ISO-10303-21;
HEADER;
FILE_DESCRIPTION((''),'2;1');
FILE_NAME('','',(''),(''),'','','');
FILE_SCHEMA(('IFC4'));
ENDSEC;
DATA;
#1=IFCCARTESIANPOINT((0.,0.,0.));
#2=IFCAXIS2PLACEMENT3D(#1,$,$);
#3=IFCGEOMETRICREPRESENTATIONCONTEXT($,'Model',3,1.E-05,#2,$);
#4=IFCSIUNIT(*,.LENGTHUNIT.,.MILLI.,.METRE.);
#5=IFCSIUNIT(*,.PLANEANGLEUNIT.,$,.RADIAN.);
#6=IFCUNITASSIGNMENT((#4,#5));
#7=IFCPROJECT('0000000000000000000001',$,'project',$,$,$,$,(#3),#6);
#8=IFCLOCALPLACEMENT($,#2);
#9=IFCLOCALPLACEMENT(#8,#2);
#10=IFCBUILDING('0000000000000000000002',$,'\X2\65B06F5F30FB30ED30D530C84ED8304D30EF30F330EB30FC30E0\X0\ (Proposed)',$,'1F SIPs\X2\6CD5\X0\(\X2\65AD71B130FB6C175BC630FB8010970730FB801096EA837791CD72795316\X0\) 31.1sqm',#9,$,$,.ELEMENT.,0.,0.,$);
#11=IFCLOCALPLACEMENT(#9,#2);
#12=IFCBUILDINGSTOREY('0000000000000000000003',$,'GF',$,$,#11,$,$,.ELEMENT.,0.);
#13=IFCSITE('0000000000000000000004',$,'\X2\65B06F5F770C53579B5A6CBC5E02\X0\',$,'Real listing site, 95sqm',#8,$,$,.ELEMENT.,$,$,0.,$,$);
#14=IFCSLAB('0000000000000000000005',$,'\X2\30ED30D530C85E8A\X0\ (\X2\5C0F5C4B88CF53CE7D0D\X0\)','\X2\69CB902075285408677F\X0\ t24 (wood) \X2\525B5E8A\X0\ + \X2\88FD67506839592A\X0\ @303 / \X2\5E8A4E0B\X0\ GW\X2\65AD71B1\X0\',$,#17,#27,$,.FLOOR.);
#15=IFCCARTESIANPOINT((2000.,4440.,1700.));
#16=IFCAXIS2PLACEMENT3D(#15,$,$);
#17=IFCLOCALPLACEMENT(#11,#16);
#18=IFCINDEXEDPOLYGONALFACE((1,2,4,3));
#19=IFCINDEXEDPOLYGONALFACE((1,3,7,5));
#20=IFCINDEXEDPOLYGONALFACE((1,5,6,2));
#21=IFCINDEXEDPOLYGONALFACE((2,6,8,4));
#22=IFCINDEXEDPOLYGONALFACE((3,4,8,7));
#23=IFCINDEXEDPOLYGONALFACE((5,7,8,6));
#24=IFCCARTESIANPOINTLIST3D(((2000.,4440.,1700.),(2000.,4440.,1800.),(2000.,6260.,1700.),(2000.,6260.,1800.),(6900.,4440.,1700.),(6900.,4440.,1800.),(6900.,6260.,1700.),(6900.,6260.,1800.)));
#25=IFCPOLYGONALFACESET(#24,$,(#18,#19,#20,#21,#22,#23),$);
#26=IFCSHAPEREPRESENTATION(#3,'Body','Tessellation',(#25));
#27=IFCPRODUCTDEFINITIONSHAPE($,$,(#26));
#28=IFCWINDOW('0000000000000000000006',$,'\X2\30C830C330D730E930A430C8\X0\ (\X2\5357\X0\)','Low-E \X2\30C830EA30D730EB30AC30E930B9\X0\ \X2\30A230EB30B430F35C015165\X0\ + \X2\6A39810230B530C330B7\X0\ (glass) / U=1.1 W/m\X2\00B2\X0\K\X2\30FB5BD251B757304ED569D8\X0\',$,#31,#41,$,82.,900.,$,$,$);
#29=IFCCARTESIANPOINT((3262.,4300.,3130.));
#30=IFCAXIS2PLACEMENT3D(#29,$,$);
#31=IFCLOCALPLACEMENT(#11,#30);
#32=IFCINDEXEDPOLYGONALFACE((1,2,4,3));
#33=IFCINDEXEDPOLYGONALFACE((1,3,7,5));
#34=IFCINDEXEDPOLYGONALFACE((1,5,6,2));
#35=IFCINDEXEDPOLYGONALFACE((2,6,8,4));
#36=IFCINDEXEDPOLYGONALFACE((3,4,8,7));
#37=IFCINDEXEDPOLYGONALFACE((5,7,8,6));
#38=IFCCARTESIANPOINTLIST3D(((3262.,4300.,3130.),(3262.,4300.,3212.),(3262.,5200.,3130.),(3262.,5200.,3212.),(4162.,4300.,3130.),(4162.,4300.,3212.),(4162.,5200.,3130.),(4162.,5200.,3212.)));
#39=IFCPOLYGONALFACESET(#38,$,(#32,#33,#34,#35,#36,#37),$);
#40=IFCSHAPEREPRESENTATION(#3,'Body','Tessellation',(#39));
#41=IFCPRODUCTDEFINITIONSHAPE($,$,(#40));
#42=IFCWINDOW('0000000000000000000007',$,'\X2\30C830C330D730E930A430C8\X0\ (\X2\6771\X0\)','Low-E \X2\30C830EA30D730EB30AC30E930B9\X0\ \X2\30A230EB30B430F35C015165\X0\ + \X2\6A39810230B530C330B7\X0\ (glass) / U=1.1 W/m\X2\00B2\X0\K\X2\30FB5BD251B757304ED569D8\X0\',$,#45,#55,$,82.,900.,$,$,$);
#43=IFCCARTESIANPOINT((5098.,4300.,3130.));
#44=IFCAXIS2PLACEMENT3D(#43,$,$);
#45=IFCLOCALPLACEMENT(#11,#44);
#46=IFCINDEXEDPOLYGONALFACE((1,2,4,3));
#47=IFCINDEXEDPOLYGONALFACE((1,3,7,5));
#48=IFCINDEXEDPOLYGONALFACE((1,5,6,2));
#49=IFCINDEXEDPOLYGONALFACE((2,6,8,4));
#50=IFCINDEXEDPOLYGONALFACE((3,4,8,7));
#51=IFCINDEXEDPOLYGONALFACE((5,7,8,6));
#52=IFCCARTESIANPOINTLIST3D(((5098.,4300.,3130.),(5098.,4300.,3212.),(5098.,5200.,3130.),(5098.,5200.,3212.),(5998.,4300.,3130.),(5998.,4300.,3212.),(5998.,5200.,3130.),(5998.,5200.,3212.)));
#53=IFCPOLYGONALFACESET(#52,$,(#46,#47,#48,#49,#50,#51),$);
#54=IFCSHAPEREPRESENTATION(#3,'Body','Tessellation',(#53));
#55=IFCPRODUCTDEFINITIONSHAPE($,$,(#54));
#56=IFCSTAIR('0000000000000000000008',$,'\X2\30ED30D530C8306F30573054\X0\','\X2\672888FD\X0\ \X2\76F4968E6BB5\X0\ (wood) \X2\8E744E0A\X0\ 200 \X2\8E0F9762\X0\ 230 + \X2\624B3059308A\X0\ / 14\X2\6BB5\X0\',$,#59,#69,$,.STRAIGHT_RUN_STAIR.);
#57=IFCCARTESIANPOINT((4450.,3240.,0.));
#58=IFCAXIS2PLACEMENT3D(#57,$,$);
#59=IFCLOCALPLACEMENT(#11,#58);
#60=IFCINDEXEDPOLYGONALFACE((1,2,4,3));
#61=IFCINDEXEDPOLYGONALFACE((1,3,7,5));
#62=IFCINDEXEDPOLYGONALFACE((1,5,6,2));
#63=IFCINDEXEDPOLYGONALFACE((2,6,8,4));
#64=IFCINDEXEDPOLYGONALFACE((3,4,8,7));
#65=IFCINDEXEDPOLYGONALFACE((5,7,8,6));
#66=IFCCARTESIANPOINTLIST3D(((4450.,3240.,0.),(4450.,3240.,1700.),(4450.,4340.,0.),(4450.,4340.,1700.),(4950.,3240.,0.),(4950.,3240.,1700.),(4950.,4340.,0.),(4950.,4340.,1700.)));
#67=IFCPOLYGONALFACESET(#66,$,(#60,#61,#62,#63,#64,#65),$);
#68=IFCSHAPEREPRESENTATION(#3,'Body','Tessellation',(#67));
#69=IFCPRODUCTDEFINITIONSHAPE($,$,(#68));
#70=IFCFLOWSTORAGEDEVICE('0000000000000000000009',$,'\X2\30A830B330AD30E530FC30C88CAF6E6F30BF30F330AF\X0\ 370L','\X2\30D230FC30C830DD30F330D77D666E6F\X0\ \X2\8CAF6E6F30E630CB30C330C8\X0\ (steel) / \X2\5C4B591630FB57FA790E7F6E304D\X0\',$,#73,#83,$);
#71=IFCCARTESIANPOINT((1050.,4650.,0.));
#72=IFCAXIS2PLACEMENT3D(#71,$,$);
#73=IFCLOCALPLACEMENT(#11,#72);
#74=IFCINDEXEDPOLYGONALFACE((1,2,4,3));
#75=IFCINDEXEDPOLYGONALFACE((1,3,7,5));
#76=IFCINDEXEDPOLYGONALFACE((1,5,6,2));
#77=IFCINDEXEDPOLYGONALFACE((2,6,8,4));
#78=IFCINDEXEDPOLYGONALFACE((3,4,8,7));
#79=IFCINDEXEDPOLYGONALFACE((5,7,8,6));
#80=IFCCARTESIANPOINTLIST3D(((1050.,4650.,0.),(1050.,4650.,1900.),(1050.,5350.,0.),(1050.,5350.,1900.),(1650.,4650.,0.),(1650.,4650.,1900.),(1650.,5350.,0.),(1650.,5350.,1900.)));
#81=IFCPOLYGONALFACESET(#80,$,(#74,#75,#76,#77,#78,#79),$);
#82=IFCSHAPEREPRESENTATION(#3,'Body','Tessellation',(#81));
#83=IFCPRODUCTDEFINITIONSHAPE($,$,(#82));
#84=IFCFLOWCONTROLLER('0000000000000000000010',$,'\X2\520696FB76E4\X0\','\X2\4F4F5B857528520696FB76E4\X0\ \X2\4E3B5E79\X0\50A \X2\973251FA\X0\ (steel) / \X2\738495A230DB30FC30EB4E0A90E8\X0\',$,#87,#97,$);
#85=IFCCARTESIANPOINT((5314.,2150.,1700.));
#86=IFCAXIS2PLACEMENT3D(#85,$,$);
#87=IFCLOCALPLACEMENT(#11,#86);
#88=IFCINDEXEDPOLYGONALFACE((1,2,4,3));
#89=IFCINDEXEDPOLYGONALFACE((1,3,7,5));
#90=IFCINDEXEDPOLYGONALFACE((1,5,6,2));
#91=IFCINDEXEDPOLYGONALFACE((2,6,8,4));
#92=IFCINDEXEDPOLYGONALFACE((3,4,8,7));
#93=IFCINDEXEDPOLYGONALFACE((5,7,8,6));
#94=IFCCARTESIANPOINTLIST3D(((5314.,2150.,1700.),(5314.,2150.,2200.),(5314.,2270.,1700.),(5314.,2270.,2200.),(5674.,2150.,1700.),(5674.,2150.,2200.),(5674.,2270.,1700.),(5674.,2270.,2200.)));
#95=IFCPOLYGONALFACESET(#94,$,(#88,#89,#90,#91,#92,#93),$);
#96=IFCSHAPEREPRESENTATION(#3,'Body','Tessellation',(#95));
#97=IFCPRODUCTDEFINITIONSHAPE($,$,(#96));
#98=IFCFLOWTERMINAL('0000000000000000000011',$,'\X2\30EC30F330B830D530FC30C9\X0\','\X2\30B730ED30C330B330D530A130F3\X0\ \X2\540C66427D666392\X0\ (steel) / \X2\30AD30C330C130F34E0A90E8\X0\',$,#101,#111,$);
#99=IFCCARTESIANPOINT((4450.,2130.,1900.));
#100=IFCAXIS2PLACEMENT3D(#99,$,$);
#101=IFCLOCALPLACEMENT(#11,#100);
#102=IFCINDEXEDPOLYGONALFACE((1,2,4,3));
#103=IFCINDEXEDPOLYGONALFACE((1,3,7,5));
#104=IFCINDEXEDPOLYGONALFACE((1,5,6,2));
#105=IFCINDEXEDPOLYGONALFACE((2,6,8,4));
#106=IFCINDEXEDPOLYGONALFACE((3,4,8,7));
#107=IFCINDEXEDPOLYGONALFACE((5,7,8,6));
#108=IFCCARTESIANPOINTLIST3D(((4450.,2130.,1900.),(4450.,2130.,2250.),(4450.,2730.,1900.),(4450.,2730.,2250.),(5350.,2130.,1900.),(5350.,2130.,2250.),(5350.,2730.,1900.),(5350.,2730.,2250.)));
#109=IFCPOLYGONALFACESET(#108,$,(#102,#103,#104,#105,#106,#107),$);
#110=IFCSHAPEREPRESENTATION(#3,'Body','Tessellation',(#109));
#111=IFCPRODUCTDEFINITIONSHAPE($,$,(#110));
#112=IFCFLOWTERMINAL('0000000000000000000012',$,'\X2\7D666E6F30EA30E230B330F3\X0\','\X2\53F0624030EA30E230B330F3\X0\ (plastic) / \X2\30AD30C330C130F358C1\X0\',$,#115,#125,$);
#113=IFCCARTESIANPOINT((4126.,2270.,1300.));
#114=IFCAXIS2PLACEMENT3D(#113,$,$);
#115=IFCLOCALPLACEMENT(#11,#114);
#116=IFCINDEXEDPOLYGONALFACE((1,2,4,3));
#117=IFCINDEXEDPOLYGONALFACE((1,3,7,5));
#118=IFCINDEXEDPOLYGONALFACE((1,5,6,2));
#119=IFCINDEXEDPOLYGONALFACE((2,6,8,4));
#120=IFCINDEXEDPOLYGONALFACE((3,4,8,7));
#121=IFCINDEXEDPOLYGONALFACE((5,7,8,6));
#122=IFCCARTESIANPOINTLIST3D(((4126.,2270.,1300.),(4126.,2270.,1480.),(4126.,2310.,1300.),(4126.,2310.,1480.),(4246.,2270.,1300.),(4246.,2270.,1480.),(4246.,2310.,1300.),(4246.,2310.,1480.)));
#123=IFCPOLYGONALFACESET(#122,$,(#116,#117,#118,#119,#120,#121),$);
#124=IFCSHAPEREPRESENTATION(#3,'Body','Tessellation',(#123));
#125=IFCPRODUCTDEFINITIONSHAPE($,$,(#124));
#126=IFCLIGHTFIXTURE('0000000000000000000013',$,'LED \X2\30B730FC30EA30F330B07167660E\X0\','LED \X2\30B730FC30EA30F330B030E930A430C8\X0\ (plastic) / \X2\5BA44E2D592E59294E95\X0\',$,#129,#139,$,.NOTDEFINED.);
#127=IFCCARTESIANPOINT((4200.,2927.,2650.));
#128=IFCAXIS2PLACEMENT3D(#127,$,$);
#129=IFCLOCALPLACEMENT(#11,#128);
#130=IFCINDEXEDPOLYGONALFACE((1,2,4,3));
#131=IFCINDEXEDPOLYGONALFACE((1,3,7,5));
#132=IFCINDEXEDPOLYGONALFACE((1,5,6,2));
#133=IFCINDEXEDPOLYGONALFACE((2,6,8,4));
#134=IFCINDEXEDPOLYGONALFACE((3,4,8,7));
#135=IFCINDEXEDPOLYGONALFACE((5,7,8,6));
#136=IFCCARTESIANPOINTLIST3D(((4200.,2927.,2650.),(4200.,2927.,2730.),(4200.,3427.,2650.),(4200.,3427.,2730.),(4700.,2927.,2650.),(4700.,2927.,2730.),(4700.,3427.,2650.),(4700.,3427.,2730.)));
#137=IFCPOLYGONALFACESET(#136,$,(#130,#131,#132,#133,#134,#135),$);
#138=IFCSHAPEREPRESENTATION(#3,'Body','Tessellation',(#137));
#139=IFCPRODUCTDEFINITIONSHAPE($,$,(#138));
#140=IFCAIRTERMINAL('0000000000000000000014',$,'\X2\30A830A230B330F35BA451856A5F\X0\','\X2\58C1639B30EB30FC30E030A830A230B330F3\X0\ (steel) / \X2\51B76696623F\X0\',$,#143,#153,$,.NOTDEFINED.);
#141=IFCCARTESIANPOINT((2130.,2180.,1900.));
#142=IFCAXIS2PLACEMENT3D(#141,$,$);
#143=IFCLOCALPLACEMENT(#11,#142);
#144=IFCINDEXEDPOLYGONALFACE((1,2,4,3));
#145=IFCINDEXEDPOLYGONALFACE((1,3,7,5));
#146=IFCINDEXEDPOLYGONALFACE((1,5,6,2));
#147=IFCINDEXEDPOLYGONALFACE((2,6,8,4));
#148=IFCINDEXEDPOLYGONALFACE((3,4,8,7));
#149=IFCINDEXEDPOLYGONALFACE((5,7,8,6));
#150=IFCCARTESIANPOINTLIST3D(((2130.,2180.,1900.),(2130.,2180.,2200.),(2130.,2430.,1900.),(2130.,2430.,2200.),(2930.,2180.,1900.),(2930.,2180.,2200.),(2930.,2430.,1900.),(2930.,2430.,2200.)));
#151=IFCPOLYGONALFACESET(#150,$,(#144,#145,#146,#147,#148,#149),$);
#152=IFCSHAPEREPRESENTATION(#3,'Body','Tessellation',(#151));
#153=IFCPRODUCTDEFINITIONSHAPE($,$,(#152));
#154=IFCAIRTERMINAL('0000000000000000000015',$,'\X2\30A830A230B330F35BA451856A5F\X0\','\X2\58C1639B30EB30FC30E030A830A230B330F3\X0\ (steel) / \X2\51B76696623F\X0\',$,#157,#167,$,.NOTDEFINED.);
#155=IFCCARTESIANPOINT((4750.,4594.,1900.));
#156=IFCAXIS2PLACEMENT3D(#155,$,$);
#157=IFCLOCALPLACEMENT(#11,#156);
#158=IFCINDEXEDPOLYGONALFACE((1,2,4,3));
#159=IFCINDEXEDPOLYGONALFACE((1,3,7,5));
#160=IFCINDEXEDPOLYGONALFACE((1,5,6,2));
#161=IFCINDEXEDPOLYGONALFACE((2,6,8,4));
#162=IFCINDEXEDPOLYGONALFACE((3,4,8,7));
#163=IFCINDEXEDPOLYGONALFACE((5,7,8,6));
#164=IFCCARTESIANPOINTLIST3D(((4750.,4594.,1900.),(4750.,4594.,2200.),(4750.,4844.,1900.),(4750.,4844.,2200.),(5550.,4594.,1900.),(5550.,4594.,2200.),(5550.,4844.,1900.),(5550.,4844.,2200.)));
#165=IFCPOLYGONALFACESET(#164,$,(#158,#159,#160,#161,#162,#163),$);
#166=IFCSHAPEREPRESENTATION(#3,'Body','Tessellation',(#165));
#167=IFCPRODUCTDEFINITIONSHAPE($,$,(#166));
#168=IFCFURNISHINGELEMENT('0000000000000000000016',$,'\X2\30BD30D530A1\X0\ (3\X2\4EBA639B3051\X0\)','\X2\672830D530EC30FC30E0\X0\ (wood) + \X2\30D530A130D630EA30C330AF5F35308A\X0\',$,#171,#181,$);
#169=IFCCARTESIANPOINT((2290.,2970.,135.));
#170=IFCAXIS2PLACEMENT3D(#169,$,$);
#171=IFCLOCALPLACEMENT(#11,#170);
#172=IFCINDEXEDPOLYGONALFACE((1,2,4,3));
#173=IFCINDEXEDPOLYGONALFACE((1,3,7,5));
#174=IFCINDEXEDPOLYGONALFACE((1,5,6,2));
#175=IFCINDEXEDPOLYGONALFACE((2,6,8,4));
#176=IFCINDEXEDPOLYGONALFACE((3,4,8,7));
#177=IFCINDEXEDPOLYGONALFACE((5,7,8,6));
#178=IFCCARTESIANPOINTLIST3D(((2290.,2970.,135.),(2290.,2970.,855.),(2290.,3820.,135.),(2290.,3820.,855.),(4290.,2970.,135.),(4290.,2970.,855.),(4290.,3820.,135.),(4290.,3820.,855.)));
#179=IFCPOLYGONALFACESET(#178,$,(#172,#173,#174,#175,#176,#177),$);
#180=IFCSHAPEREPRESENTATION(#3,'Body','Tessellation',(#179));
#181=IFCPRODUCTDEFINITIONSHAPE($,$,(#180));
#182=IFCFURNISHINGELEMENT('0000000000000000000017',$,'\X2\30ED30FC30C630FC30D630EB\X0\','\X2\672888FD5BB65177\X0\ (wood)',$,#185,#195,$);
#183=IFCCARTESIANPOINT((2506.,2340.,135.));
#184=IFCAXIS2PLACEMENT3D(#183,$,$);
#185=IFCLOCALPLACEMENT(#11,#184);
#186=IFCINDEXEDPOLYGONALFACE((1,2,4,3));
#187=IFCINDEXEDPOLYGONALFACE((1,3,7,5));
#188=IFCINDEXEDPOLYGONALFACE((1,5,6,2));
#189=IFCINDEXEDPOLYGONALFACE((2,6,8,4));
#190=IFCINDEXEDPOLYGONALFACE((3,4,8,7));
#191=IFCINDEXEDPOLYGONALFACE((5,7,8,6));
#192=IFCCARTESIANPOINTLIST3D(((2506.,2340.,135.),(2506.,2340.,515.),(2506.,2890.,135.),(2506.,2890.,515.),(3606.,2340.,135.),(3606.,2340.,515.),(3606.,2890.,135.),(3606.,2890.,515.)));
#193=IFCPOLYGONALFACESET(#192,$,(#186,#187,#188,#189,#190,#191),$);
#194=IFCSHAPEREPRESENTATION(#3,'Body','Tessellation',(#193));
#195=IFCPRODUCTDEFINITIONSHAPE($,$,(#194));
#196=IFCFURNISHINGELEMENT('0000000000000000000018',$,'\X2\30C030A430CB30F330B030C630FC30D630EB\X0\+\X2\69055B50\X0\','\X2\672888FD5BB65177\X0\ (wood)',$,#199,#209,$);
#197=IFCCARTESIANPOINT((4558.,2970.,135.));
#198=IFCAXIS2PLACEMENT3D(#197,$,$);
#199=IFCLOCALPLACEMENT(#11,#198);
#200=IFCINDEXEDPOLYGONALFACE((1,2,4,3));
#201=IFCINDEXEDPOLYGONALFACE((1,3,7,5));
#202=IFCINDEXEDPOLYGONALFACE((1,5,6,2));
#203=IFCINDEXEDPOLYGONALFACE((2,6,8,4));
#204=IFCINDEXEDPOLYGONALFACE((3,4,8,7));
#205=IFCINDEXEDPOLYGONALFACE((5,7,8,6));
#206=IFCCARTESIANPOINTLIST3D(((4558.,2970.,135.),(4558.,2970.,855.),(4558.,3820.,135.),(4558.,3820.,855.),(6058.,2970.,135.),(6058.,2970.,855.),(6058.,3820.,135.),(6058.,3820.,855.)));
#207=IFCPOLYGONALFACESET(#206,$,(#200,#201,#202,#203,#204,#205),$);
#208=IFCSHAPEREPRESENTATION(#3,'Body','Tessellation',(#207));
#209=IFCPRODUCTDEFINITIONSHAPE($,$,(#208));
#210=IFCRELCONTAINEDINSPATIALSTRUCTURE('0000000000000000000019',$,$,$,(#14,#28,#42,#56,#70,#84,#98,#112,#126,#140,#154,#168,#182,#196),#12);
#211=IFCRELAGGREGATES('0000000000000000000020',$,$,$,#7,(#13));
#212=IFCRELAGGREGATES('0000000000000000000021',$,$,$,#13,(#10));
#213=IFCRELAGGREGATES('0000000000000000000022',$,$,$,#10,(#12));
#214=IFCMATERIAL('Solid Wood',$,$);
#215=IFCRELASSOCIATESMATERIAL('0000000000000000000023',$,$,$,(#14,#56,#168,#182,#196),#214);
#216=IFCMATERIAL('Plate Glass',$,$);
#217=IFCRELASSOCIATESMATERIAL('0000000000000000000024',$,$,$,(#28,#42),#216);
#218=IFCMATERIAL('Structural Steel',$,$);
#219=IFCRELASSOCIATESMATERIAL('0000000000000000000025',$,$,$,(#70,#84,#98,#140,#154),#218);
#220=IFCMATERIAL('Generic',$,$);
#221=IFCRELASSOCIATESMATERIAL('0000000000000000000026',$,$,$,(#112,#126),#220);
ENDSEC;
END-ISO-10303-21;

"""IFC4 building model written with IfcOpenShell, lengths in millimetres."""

from ifc_helpers import new_model, si_unit, frame, frame_2d, origin, place, context, project, spatial, rectangle, extrude, material, element, save


model = new_model("IFC4")

# Units and contexts
model_context = context("Model", 3, precision=1e-05, world=origin())
ifc_project = project(units=[si_unit("LENGTHUNIT", "METRE", prefix="MILLI"), si_unit("PLANEANGLEUNIT", "RADIAN")], contexts=[model_context])

# Site, building, storey
site_placement = place(None, origin())
site = spatial("IfcSite", under=ifc_project, at=site_placement, Name="新潟県南魚沼市", ObjectType="Real listing site, 95sqm", CompositionType="ELEMENT", RefElevation=0.0)
building_placement = place(site_placement, origin())
building = spatial("IfcBuilding", under=site, at=building_placement, Name="新潟・ロフト付きワンルーム (Proposed)", ObjectType="1F SIPs法(断熱・気密・耐震・耐雪荷重特化) 31.1sqm", CompositionType="ELEMENT", ElevationOfRefHeight=0.0, ElevationOfTerrain=0.0)
storey_placement = place(building_placement, origin())
storey = spatial("IfcBuildingStorey", under=building, at=storey_placement, Name="GF", CompositionType="ELEMENT", Elevation=0.0)

# Shared definitions
ifc_material_1 = material(Name="Solid Wood")

# Slab
slab_placement = place(storey_placement, frame((2000.0, 4440.0, 1700.0)))
element("IfcSlab", 1, at=slab_placement, inside=storey, material=ifc_material_1, Name="ロフト床 (小屋裏収納)", Description="構造用合板 t24 (wood) 剛床 + 製材根太 @303 / 床下 GW断熱", PredefinedType="FLOOR", context=model_context, shape_type="SweptSolid", body=[
    extrude(rectangle(XDim=4900.0, YDim=1820.0, at=frame_2d((2450.0, 910.0))), frame((2000.0, 4440.0, 1700.0)), (0.0, 0.0, 1.0), 100.0),
])

# Windows
ifc_material_2 = material(Name="Plate Glass")
window_1_placement = place(storey_placement, frame((3262.0, 4300.0, 3130.0)))
element("IfcWindow", 2, at=window_1_placement, inside=storey, material=ifc_material_2, Name="トップライト (南)", Description="Low-E トリプルガラス アルゴン封入 + 樹脂サッシ (glass) / U=1.1 W/m²K・寒冷地仕様", OverallHeight=82.0, OverallWidth=900.0, context=model_context, shape_type="SweptSolid", body=[
    extrude(rectangle(XDim=900.0, YDim=900.0, at=frame_2d((450.0, 450.0))), frame((3262.0, 4300.0, 3130.0)), (0.0, 0.0, 1.0), 82.0),
])
window_2_placement = place(storey_placement, frame((5098.0, 4300.0, 3130.0)))
element("IfcWindow", 3, at=window_2_placement, inside=storey, material=ifc_material_2, Name="トップライト (東)", Description="Low-E トリプルガラス アルゴン封入 + 樹脂サッシ (glass) / U=1.1 W/m²K・寒冷地仕様", OverallHeight=82.0, OverallWidth=900.0, context=model_context, shape_type="SweptSolid", body=[
    extrude(rectangle(XDim=900.0, YDim=900.0, at=frame_2d((450.0, 450.0))), frame((5098.0, 4300.0, 3130.0)), (0.0, 0.0, 1.0), 82.0),
])

# Stair
stair_placement = place(storey_placement, frame((4450.0, 3240.0, 0.0)))
element("IfcStair", 4, at=stair_placement, inside=storey, material=ifc_material_1, Name="ロフトはしご", Description="木製 直階段 (wood) 蹴上 200 踏面 230 + 手すり / 14段", PredefinedType="STRAIGHT_RUN_STAIR", context=model_context, shape_type="SweptSolid", body=[
    extrude(rectangle(XDim=500.0, YDim=1100.0, at=frame_2d((250.0, 550.0))), frame((4450.0, 3240.0, 0.0)), (0.0, 0.0, 1.0), 1700.0),
])

# Flow storage device
ifc_material_3 = material(Name="Structural Steel")
flow_storage_device_placement = place(storey_placement, frame((1050.0, 4650.0, 0.0)))
element("IfcFlowStorageDevice", 5, at=flow_storage_device_placement, inside=storey, material=ifc_material_3, Name="エコキュート貯湯タンク 370L", Description="ヒートポンプ給湯 貯湯ユニット (steel) / 屋外・基礎置き", context=model_context, shape_type="SweptSolid", body=[
    extrude(rectangle(XDim=600.0, YDim=700.0, at=frame_2d((300.0, 350.0))), frame((1050.0, 4650.0, 0.0)), (0.0, 0.0, 1.0), 1900.0),
])

# Flow controller
flow_controller_placement = place(storey_placement, frame((5314.0, 2150.0, 1700.0)))
element("IfcFlowController", 6, at=flow_controller_placement, inside=storey, material=ifc_material_3, Name="分電盤", Description="住宅用分電盤 主幹50A 露出 (steel) / 玄関ホール上部", context=model_context, shape_type="SweptSolid", body=[
    extrude(rectangle(XDim=360.0, YDim=120.0, at=frame_2d((180.0, 60.0))), frame((5314.0, 2150.0, 1700.0)), (0.0, 0.0, 1.0), 500.0),
])

# Flow terminals
flow_terminal_1_placement = place(storey_placement, frame((4450.0, 2130.0, 1900.0)))
element("IfcFlowTerminal", 7, at=flow_terminal_1_placement, inside=storey, material=ifc_material_3, Name="レンジフード", Description="シロッコファン 同時給排 (steel) / キッチン上部", context=model_context, shape_type="SweptSolid", body=[
    extrude(rectangle(XDim=900.0, YDim=600.0, at=frame_2d((450.0, 300.0))), frame((4450.0, 2130.0, 1900.0)), (0.0, 0.0, 1.0), 350.0),
])
ifc_material_4 = material(Name="Generic")
flow_terminal_2_placement = place(storey_placement, frame((4126.0, 2270.0, 1300.0)))
element("IfcFlowTerminal", 8, at=flow_terminal_2_placement, inside=storey, material=ifc_material_4, Name="給湯リモコン", Description="台所リモコン (plastic) / キッチン壁", context=model_context, shape_type="SweptSolid", body=[
    extrude(rectangle(XDim=120.0, YDim=40.0, at=frame_2d((60.0, 20.0))), frame((4126.0, 2270.0, 1300.0)), (0.0, 0.0, 1.0), 180.0),
])

# Light fixture
light_fixture_placement = place(storey_placement, frame((4200.0, 2927.0, 2650.0)))
element("IfcLightFixture", 9, at=light_fixture_placement, inside=storey, material=ifc_material_4, Name="LED シーリング照明", Description="LED シーリングライト (plastic) / 室中央天井", PredefinedType="NOTDEFINED", context=model_context, shape_type="SweptSolid", body=[
    extrude(rectangle(XDim=500.0, YDim=500.0, at=frame_2d((250.0, 250.0))), frame((4200.0, 2927.0, 2650.0)), (0.0, 0.0, 1.0), 80.0),
])

# Air terminals
air_terminal_1_placement = place(storey_placement, frame((2130.0, 2180.0, 1900.0)))
element("IfcAirTerminal", 10, at=air_terminal_1_placement, inside=storey, material=ifc_material_3, Name="エアコン室内機", Description="壁掛ルームエアコン (steel) / 冷暖房", PredefinedType="NOTDEFINED", context=model_context, shape_type="SweptSolid", body=[
    extrude(rectangle(XDim=800.0, YDim=250.0, at=frame_2d((400.0, 125.0))), frame((2130.0, 2180.0, 1900.0)), (0.0, 0.0, 1.0), 300.0),
])
air_terminal_2_placement = place(storey_placement, frame((4750.0, 4594.0, 1900.0)))
element("IfcAirTerminal", 11, at=air_terminal_2_placement, inside=storey, material=ifc_material_3, Name="エアコン室内機", Description="壁掛ルームエアコン (steel) / 冷暖房", PredefinedType="NOTDEFINED", context=model_context, shape_type="SweptSolid", body=[
    extrude(rectangle(XDim=800.0, YDim=250.0, at=frame_2d((400.0, 125.0))), frame((4750.0, 4594.0, 1900.0)), (0.0, 0.0, 1.0), 300.0),
])

# Furnishing elements
furnishing_1_placement = place(storey_placement, frame((2290.0, 2970.0, 135.0)))
element("IfcFurnishingElement", 12, at=furnishing_1_placement, inside=storey, material=ifc_material_1, Name="ソファ (3人掛け)", Description="木フレーム (wood) + ファブリック張り", context=model_context, shape_type="SweptSolid", body=[
    extrude(rectangle(XDim=2000.0, YDim=850.0, at=frame_2d((1000.0, 425.0))), frame((2290.0, 2970.0, 135.0)), (0.0, 0.0, 1.0), 720.0),
])
furnishing_2_placement = place(storey_placement, frame((2506.0, 2340.0, 135.0)))
element("IfcFurnishingElement", 13, at=furnishing_2_placement, inside=storey, material=ifc_material_1, Name="ローテーブル", Description="木製家具 (wood)", context=model_context, shape_type="SweptSolid", body=[
    extrude(rectangle(XDim=1100.0, YDim=550.0, at=frame_2d((550.0, 275.0))), frame((2506.0, 2340.0, 135.0)), (0.0, 0.0, 1.0), 380.0),
])
furnishing_3_placement = place(storey_placement, frame((4558.0, 2970.0, 135.0)))
element("IfcFurnishingElement", 14, at=furnishing_3_placement, inside=storey, material=ifc_material_1, Name="ダイニングテーブル+椅子", Description="木製家具 (wood)", context=model_context, shape_type="SweptSolid", body=[
    extrude(rectangle(XDim=1500.0, YDim=850.0, at=frame_2d((750.0, 425.0))), frame((4558.0, 2970.0, 135.0)), (0.0, 0.0, 1.0), 720.0),
])

save(model, "model.ifc")
